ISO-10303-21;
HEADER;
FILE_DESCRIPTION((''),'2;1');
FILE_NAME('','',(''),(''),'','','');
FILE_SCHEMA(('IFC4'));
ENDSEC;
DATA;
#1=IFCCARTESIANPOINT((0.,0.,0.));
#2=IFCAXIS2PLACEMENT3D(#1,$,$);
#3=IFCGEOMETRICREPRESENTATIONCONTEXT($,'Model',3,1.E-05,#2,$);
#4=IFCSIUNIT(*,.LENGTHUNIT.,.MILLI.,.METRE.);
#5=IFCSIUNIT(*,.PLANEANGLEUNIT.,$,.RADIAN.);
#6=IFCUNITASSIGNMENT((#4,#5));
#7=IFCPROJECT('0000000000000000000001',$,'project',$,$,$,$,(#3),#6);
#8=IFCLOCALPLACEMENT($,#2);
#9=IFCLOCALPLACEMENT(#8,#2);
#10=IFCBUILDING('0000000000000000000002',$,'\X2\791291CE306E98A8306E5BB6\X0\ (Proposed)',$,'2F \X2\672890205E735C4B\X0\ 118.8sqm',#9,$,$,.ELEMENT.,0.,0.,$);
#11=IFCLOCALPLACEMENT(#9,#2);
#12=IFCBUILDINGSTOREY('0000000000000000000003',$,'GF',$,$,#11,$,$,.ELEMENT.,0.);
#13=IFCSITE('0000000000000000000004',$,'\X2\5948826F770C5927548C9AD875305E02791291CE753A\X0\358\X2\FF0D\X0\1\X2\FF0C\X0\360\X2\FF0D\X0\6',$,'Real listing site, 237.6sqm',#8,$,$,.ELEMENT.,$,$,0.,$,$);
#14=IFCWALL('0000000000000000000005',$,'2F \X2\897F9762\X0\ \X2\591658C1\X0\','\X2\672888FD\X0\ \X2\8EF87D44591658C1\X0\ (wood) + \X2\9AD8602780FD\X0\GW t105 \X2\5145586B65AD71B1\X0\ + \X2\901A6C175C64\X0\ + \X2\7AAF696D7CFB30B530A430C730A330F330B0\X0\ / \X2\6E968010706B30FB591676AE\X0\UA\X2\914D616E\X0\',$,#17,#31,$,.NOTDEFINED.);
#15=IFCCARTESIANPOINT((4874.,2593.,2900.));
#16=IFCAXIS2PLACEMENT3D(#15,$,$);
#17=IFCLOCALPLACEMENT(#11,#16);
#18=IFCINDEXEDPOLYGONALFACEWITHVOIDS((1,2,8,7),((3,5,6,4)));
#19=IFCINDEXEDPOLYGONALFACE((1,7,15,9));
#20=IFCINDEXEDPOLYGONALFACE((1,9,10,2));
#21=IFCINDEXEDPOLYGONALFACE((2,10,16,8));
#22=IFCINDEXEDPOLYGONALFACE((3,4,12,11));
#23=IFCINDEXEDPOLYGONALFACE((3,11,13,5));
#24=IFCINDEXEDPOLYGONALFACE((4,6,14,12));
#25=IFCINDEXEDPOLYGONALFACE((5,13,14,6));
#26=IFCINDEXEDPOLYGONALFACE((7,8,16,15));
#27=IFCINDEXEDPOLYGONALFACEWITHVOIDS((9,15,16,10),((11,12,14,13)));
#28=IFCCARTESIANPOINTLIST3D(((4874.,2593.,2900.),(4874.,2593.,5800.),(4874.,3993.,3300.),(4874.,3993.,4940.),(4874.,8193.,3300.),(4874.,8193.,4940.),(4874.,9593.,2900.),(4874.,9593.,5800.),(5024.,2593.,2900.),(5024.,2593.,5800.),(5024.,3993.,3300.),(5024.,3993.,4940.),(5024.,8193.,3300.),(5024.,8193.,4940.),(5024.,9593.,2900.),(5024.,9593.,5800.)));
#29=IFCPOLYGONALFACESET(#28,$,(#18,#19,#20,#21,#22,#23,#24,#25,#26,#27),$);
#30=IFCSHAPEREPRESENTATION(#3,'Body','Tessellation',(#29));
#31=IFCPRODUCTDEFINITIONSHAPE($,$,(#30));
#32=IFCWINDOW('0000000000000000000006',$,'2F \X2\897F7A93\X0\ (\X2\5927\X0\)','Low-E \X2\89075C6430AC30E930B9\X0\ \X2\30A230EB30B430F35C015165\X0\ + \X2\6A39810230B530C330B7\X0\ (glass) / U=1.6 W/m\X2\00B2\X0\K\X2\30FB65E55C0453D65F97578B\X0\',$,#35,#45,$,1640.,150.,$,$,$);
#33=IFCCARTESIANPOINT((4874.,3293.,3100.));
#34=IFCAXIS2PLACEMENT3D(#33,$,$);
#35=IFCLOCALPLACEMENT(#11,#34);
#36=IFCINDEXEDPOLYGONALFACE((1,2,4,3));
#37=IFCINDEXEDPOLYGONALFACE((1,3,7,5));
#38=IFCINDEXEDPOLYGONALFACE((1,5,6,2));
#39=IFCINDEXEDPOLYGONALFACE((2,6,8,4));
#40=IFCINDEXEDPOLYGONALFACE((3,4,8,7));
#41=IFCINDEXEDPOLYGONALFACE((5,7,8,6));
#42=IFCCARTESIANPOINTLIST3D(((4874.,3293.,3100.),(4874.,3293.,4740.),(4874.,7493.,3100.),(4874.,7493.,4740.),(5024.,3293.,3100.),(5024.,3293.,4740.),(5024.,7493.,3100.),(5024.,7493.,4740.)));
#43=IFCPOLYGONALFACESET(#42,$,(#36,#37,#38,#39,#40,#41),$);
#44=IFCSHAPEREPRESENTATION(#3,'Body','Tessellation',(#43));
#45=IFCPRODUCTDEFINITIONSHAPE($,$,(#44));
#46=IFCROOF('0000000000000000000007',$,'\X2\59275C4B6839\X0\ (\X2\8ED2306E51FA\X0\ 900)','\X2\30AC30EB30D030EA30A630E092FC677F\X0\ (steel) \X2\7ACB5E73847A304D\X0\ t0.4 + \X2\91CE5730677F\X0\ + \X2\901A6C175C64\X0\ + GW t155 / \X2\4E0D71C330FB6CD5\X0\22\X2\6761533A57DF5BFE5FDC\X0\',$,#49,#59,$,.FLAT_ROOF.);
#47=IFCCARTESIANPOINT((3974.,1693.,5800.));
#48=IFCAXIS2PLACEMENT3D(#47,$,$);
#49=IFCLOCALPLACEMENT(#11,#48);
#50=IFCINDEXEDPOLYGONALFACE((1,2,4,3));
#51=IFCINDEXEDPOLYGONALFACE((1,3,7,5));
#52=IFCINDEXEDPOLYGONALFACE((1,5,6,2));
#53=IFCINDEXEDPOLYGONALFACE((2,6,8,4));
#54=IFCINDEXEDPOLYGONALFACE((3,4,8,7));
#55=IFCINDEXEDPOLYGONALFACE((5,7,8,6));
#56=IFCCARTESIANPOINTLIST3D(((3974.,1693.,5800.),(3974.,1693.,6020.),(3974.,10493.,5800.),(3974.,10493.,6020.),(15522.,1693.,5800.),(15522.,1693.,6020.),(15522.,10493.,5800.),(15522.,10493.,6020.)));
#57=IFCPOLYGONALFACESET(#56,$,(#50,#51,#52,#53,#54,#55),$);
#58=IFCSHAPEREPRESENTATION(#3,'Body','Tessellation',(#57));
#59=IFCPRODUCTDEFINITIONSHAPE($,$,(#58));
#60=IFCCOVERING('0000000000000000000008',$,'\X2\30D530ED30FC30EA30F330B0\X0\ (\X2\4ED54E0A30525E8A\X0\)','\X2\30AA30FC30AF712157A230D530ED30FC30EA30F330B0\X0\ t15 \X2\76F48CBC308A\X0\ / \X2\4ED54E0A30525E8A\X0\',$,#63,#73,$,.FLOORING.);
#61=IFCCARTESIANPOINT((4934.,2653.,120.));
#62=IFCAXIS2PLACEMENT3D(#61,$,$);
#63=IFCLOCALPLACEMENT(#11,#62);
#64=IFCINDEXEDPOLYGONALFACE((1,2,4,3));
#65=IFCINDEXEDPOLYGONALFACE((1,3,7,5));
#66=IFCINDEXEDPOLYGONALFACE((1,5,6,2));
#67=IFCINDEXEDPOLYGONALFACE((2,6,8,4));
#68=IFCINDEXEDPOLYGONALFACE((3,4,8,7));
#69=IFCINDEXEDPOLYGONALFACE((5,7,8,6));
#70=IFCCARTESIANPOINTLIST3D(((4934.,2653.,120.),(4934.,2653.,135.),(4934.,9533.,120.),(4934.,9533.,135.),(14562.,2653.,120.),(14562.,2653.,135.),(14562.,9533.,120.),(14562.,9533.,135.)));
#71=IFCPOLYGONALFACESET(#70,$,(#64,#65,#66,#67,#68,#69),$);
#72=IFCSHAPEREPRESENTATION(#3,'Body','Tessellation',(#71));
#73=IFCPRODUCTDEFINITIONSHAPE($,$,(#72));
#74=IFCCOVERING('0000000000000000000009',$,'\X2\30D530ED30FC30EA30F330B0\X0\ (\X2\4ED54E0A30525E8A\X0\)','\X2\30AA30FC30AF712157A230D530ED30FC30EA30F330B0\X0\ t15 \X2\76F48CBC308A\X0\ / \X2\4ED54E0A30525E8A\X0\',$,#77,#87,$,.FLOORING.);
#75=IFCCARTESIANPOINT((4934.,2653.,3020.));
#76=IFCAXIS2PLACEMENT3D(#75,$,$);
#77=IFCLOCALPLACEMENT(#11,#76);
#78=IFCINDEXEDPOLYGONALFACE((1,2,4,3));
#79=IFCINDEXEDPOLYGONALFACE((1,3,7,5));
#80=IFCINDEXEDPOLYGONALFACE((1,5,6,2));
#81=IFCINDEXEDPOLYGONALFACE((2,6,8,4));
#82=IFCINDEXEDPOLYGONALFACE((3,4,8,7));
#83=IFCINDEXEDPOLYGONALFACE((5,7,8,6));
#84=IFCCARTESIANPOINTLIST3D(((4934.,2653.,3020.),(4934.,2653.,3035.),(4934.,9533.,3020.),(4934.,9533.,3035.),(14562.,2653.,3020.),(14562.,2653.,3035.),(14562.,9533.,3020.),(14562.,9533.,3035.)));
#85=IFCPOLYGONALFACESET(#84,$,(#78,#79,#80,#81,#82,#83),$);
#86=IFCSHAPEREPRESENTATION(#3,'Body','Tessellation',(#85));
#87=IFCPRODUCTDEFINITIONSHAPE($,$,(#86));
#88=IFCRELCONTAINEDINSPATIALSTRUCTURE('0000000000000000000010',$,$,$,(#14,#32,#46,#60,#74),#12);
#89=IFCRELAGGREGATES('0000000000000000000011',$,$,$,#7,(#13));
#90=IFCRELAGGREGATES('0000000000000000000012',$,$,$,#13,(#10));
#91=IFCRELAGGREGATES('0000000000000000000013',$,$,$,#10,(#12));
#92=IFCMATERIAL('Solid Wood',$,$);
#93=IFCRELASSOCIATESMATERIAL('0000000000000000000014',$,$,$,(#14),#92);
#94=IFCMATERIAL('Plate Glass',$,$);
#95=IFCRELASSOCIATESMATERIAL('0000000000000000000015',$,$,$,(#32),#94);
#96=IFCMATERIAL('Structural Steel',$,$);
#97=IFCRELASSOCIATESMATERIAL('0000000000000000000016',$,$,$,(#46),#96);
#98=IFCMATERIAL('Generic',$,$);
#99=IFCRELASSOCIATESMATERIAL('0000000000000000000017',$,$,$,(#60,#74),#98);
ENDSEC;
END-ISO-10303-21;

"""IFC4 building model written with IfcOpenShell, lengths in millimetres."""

from ifc_helpers import new_model, si_unit, frame, frame_2d, origin, place, context, project, spatial, rectangle, extrude, material, element, fill, save


model = new_model("IFC4")

# Units and contexts
model_context = context("Model", 3, precision=1e-05, world=origin())
ifc_project = project(units=[si_unit("LENGTHUNIT", "METRE", prefix="MILLI"), si_unit("PLANEANGLEUNIT", "RADIAN")], contexts=[model_context])

# Site, building, storey
site_placement = place(None, origin())
site = spatial("IfcSite", under=ifc_project, at=site_placement, Name="奈良県大和高田市礒野町358－1，360－6", ObjectType="Real listing site, 237.6sqm", CompositionType="ELEMENT", RefElevation=0.0)
building_placement = place(site_placement, origin())
building = spatial("IfcBuilding", under=site, at=building_placement, Name="礒野の風の家 (Proposed)", ObjectType="2F 木造平屋 118.8sqm", CompositionType="ELEMENT", ElevationOfRefHeight=0.0, ElevationOfTerrain=0.0)
storey_placement = place(building_placement, origin())
storey = spatial("IfcBuildingStorey", under=building, at=storey_placement, Name="GF", CompositionType="ELEMENT", Elevation=0.0)

# Shared definitions
ifc_material_1 = material(Name="Solid Wood")

# Shared definitions
ifc_material_2 = material(Name="Plate Glass")

# Wall, opening, window
wall_1_placement = place(storey_placement, frame((4874.0, 2593.0, 2900.0)))
wall_1 = element("IfcWall", 1, at=wall_1_placement, inside=storey, material=ifc_material_1, Name="2F 西面 外壁", Description="木製 軸組外壁 (wood) + 高性能GW t105 充填断熱 + 通気層 + 窯業系サイディング / 準耐火・外皮UA配慮", PredefinedType="NOTDEFINED", context=model_context, shape_type="SweptSolid", body=[
    extrude(rectangle(XDim=150.0, YDim=7000.0, at=frame_2d((75.0, 3500.0))), frame((4874.0, 2593.0, 2900.0)), (0.0, 0.0, 1.0), 2900.0),
])
opening_1_placement = place(storey_placement, frame((4874.0, 3293.0, 3100.0)))
opening_1 = element("IfcOpeningElement", 2, at=opening_1_placement, cuts=wall_1, PredefinedType="NOTDEFINED", context=model_context, shape_type="SweptSolid", body=[
    extrude(rectangle(XDim=150.0, YDim=4200.0, at=frame_2d((75.0, 2100.0))), frame((4874.0, 3293.0, 3100.0)), (0.0, 0.0, 1.0), 1640.0),
])
window_1_placement = place(storey_placement, frame((4874.0, 3293.0, 3100.0)))
window_1 = element("IfcWindow", 3, at=window_1_placement, inside=storey, material=ifc_material_2, Name="2F 西窓 (大)", Description="Low-E 複層ガラス アルゴン封入 + 樹脂サッシ (glass) / U=1.6 W/m²K・日射取得型", OverallHeight=1640.0, OverallWidth=150.0, context=model_context, shape_type="SweptSolid", body=[
    extrude(rectangle(XDim=150.0, YDim=4200.0, at=frame_2d((75.0, 2100.0))), frame((4874.0, 3293.0, 3100.0)), (0.0, 0.0, 1.0), 1640.0),
])
fill(opening_1, window_1)

# Roof
ifc_material_3 = material(Name="Structural Steel")
roof_placement = place(storey_placement, frame((3974.0, 1693.0, 5800.0)))
element("IfcRoof", 4, at=roof_placement, inside=storey, material=ifc_material_3, Name="大屋根 (軒の出 900)", Description="ガルバリウム鋼板 (steel) 立平葺き t0.4 + 野地板 + 通気層 + GW t155 / 不燃・法22条区域対応", PredefinedType="FLAT_ROOF", context=model_context, shape_type="SweptSolid", body=[
    extrude(rectangle(XDim=11548.0, YDim=8800.0, at=frame_2d((5774.0, 4400.0))), frame((3974.0, 1693.0, 5800.0)), (0.0, 0.0, 1.0), 220.0),
])

# Coverings
ifc_material_4 = material(Name="Generic")
covering_1_placement = place(storey_placement, frame((4934.0, 2653.0, 120.0)))
element("IfcCovering", 5, at=covering_1_placement, inside=storey, material=ifc_material_4, Name="フローリング (仕上げ床)", Description="オーク無垢フローリング t15 直貼り / 仕上げ床", PredefinedType="FLOORING", context=model_context, shape_type="SweptSolid", body=[
    extrude(rectangle(XDim=9628.0, YDim=6880.0, at=frame_2d((4814.0, 3440.0))), frame((4934.0, 2653.0, 120.0)), (0.0, 0.0, 1.0), 15.0),
])
covering_2_placement = place(storey_placement, frame((4934.0, 2653.0, 3020.0)))
element("IfcCovering", 6, at=covering_2_placement, inside=storey, material=ifc_material_4, Name="フローリング (仕上げ床)", Description="オーク無垢フローリング t15 直貼り / 仕上げ床", PredefinedType="FLOORING", context=model_context, shape_type="SweptSolid", body=[
    extrude(rectangle(XDim=9628.0, YDim=6880.0, at=frame_2d((4814.0, 3440.0))), frame((4934.0, 2653.0, 3020.0)), (0.0, 0.0, 1.0), 15.0),
])

save(model, "model.ifc")
